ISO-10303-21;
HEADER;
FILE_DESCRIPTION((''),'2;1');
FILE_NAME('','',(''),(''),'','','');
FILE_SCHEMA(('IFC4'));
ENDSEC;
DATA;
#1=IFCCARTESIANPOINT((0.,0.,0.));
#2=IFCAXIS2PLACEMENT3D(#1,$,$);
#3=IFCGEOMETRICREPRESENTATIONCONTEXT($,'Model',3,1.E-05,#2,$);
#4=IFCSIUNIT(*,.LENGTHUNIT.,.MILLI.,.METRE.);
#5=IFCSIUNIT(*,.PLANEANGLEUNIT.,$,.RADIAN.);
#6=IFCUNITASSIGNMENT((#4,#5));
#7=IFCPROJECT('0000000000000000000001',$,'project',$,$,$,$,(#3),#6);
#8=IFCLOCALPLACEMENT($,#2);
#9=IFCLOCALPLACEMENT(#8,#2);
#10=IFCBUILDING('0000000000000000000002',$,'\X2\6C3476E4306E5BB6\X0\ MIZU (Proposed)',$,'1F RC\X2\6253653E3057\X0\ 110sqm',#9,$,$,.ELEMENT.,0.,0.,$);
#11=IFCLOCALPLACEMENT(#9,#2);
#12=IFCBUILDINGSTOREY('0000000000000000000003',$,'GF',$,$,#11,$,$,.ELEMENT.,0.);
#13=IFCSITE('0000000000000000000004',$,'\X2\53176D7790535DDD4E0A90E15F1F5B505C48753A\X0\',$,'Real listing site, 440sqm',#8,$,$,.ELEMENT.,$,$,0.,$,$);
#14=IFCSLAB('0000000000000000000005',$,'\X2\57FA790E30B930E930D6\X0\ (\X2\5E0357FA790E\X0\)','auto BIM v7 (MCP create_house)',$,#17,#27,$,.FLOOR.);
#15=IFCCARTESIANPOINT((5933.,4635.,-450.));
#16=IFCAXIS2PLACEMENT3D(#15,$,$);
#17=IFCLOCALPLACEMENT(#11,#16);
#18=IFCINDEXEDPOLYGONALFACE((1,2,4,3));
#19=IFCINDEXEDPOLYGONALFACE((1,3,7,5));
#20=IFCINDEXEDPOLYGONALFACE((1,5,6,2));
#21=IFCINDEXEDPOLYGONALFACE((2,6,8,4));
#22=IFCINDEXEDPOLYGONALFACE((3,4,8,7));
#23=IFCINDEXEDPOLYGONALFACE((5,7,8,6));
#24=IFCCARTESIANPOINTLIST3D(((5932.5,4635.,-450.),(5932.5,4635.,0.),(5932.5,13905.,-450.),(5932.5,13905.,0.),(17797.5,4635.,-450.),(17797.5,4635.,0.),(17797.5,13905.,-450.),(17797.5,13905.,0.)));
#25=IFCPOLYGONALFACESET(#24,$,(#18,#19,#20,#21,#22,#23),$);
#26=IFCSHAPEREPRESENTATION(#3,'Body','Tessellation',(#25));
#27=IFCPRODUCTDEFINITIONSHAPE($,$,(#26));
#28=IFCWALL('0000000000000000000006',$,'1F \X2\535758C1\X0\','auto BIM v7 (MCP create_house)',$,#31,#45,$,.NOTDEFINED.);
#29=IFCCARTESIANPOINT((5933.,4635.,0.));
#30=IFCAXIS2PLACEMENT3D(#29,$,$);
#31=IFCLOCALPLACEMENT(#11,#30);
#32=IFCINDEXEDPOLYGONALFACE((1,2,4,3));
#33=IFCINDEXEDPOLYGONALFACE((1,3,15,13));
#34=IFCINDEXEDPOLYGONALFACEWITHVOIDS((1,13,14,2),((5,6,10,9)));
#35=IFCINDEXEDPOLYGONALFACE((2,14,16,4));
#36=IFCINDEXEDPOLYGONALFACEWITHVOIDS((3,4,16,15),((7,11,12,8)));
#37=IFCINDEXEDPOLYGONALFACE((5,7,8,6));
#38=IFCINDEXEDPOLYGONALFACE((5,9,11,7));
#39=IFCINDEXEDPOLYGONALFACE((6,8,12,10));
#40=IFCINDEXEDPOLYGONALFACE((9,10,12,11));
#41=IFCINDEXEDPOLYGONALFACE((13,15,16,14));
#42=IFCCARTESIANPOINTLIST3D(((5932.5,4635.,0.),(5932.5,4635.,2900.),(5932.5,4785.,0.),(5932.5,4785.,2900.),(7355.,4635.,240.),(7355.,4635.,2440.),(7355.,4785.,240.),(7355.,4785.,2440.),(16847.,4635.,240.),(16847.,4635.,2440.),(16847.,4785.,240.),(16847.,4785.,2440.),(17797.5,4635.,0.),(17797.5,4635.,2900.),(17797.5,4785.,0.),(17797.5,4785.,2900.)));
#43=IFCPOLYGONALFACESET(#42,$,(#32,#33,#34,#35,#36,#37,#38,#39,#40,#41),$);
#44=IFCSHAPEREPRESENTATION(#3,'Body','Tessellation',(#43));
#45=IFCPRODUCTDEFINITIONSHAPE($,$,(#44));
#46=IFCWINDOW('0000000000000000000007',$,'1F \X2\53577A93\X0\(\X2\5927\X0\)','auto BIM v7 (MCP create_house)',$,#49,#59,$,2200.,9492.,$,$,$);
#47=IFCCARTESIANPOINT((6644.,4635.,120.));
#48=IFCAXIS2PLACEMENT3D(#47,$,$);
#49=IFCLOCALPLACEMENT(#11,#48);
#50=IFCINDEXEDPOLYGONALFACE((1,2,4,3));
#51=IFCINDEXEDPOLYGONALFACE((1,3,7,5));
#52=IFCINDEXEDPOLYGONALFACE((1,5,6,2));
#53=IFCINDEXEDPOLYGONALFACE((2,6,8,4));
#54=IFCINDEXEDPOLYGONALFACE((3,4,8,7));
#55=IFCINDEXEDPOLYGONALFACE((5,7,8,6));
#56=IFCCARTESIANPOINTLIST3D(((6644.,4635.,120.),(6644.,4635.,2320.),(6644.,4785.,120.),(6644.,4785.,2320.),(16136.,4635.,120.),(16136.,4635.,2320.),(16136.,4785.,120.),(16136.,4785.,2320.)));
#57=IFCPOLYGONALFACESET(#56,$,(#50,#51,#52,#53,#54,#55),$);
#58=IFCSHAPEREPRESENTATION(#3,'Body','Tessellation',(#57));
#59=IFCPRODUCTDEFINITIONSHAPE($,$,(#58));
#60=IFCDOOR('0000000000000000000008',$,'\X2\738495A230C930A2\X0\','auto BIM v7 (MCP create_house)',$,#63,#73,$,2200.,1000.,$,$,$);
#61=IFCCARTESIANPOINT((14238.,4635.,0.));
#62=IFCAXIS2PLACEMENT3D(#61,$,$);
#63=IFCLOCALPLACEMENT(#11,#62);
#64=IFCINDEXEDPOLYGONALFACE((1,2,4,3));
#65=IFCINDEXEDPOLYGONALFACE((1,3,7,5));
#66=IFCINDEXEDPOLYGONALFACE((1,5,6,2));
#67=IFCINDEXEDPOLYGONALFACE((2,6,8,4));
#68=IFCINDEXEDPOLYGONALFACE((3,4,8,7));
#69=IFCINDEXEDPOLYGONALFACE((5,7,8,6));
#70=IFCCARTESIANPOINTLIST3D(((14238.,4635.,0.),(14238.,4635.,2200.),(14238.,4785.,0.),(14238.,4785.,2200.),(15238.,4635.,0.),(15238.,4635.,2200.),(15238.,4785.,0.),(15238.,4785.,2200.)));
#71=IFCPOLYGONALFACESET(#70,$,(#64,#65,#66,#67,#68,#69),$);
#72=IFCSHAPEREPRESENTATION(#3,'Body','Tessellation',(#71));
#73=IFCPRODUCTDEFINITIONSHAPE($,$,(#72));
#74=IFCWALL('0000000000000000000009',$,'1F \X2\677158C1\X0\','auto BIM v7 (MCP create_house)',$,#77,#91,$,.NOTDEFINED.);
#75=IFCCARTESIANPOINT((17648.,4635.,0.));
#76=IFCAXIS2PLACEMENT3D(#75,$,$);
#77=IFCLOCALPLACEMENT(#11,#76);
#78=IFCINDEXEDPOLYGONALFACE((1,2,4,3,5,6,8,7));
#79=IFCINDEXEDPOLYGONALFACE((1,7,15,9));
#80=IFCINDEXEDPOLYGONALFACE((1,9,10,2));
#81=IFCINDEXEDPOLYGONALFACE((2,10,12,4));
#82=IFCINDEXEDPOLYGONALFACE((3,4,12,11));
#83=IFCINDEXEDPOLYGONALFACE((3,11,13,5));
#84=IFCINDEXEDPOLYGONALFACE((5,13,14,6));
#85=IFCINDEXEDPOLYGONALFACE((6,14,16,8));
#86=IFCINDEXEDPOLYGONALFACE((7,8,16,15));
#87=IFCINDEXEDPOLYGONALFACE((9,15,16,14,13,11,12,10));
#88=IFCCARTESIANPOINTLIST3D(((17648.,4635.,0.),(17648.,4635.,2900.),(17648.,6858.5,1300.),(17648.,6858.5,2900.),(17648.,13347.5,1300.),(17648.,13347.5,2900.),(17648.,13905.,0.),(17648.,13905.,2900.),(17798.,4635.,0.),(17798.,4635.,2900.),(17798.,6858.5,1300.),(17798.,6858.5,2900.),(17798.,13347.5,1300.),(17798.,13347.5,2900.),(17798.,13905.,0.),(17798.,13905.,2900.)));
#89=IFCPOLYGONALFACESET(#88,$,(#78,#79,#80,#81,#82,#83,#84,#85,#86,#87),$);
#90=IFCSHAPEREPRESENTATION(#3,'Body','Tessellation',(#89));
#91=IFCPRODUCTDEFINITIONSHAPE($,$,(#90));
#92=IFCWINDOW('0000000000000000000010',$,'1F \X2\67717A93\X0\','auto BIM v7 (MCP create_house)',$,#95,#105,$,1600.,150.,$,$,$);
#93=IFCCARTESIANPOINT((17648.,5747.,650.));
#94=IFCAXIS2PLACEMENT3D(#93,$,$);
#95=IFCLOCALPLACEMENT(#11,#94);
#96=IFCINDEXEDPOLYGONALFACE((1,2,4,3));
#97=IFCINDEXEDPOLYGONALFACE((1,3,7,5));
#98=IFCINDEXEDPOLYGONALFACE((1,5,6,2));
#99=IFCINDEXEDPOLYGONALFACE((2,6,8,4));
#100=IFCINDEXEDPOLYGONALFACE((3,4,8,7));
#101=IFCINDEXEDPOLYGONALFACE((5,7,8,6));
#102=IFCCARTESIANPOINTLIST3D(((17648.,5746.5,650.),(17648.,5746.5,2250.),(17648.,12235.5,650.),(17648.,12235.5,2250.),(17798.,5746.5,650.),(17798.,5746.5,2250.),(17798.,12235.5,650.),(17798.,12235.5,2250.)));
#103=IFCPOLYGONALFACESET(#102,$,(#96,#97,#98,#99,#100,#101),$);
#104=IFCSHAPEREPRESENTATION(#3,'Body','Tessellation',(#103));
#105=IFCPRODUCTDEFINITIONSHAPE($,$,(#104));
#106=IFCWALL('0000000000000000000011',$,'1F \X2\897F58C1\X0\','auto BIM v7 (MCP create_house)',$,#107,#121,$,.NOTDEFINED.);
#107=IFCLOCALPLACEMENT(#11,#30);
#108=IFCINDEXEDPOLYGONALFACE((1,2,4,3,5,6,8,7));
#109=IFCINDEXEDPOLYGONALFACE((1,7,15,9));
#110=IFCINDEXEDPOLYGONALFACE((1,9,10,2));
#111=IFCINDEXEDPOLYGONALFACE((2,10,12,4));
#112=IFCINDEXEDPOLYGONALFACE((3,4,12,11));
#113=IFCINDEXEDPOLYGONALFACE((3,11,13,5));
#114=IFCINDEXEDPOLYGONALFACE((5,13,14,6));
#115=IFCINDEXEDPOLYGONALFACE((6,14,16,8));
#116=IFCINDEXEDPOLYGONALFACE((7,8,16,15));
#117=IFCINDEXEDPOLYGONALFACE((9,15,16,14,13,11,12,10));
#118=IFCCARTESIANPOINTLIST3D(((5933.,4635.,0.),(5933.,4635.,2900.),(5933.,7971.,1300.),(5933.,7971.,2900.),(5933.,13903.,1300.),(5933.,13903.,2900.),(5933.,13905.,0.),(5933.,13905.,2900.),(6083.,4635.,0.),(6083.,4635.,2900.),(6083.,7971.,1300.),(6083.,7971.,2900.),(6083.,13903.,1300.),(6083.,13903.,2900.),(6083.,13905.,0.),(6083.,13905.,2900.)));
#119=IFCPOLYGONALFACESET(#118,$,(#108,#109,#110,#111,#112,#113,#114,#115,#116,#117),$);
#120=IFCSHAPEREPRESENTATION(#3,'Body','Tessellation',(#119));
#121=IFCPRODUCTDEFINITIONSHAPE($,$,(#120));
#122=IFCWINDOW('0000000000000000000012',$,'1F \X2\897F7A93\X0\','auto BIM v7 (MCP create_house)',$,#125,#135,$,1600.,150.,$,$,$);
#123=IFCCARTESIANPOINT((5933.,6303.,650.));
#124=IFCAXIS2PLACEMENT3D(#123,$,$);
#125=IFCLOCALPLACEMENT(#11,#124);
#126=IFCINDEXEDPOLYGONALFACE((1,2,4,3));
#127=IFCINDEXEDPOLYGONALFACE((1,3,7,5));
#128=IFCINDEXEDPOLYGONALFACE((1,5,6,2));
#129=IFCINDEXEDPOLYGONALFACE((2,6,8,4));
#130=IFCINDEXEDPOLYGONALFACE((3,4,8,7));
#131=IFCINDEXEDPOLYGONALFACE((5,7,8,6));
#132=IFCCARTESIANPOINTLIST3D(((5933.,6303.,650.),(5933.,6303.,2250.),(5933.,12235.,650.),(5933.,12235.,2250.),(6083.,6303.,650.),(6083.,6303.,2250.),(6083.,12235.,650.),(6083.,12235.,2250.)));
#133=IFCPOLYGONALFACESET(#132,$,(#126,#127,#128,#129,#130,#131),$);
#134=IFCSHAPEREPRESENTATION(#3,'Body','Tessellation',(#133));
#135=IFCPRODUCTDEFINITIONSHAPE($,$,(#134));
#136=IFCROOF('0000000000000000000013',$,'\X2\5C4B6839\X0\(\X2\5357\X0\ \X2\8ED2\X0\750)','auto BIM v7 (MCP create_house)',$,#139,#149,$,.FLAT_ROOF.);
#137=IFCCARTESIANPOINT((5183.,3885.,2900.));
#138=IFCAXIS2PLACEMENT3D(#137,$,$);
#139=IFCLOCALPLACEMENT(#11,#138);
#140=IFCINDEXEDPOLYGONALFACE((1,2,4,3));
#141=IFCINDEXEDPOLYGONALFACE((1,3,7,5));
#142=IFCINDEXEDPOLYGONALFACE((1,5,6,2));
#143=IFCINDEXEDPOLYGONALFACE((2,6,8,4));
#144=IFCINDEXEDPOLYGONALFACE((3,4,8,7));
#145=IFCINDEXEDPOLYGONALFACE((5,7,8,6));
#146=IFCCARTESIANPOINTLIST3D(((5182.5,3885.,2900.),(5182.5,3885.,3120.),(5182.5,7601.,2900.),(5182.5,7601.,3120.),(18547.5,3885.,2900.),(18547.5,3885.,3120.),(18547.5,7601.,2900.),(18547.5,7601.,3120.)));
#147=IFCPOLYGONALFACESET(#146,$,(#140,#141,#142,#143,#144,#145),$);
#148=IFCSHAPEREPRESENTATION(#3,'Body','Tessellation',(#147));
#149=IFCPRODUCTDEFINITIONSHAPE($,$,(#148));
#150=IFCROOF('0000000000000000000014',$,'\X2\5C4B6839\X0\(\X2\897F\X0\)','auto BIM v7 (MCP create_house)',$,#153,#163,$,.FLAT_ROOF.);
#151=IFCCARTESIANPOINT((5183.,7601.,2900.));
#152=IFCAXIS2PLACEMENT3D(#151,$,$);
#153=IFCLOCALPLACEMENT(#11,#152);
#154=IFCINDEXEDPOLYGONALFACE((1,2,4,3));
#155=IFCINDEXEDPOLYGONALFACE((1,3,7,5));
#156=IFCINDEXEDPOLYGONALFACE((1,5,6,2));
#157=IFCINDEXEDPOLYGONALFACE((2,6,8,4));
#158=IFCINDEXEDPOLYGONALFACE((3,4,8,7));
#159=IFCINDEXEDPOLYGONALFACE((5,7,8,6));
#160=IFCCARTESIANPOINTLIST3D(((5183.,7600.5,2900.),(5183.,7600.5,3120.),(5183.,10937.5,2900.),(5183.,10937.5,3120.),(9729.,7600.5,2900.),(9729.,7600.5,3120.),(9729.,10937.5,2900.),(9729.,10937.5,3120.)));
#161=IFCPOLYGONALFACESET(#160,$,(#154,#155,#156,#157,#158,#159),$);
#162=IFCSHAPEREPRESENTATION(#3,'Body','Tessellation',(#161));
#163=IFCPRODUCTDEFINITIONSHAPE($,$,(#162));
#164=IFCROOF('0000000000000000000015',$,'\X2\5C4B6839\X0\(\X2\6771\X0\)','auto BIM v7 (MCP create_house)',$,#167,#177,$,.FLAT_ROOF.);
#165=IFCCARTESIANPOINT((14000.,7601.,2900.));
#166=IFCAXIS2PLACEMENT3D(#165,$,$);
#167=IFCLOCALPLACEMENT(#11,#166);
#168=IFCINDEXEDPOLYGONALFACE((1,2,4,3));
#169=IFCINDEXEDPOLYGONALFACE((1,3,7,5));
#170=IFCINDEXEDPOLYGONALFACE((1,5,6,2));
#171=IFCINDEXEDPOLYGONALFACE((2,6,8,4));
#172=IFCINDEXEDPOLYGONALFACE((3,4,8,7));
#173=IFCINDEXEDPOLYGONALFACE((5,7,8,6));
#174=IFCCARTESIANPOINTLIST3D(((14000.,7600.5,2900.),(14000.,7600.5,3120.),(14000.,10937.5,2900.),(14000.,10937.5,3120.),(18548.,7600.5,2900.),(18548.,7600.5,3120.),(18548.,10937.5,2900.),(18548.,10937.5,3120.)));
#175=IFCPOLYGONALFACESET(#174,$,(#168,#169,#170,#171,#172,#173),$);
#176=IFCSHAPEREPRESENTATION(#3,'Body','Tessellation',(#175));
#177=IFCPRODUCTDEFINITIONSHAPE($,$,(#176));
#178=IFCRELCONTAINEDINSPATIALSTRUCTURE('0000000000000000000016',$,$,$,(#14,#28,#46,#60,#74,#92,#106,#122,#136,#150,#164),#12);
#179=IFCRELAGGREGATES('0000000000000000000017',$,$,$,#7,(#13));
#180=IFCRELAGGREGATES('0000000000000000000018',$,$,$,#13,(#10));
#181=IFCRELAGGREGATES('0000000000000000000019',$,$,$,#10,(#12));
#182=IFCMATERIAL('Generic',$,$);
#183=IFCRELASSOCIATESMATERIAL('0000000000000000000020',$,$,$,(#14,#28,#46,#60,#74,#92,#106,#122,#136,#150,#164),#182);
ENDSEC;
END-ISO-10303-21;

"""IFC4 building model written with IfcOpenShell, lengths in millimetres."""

from ifc_helpers import new_model, si_unit, frame, frame_2d, origin, place, context, project, spatial, rectangle, extrude, material, element, fill, save


model = new_model("IFC4")

# Units and contexts
model_context = context("Model", 3, precision=1e-05, world=origin())
ifc_project = project(units=[si_unit("LENGTHUNIT", "METRE", prefix="MILLI"), si_unit("PLANEANGLEUNIT", "RADIAN")], contexts=[model_context])

# Site, building, storey
site_placement = place(None, origin())
site = spatial("IfcSite", under=ifc_project, at=site_placement, Name="北海道川上郡弟子屈町", ObjectType="Real listing site, 440sqm", CompositionType="ELEMENT", RefElevation=0.0)
building_placement = place(site_placement, origin())
building = spatial("IfcBuilding", under=site, at=building_placement, Name="水盤の家 MIZU (Proposed)", ObjectType="1F RC打放し 110sqm", CompositionType="ELEMENT", ElevationOfRefHeight=0.0, ElevationOfTerrain=0.0)
storey_placement = place(building_placement, origin())
storey = spatial("IfcBuildingStorey", under=building, at=storey_placement, Name="GF", CompositionType="ELEMENT", Elevation=0.0)

# Slab
ifc_material = material(Name="Generic")
slab_1_placement = place(storey_placement, frame((5933.0, 4635.0, -450.0)))
element("IfcSlab", 1, at=slab_1_placement, inside=storey, material=ifc_material, Name="基礎スラブ (布基礎)", Description="auto BIM v7 (MCP create_house)", PredefinedType="FLOOR", context=model_context, shape_type="SweptSolid", body=[
    extrude(rectangle(XDim=11865.0, YDim=9270.0, at=frame_2d((5932.0, 4635.0))), frame((5933.0, 4635.0, -450.0)), (0.0, 0.0, 1.0), 450.0),
])

# Wall, openings, window, door
wall_1_placement = place(storey_placement, frame((5933.0, 4635.0, 0.0)))
wall_1 = element("IfcWall", 2, at=wall_1_placement, inside=storey, material=ifc_material, Name="1F 南壁", Description="auto BIM v7 (MCP create_house)", PredefinedType="NOTDEFINED", context=model_context, shape_type="SweptSolid", body=[
    extrude(rectangle(XDim=11865.0, YDim=150.0, at=frame_2d((5932.0, 75.0))), frame((5933.0, 4635.0, 0.0)), (0.0, 0.0, 1.0), 2900.0),
])
opening_1_placement = place(storey_placement, frame((6644.0, 4635.0, 120.0)))
opening_1 = element("IfcOpeningElement", 3, at=opening_1_placement, cuts=wall_1, PredefinedType="NOTDEFINED", context=model_context, shape_type="SweptSolid", body=[
    extrude(rectangle(XDim=9492.0, YDim=150.0, at=frame_2d((4746.0, 75.0))), frame((6644.0, 4635.0, 120.0)), (0.0, 0.0, 1.0), 2200.0),
])
opening_2_placement = place(storey_placement, frame((14238.0, 4635.0, 0.0)))
opening_2 = element("IfcOpeningElement", 4, at=opening_2_placement, cuts=wall_1, PredefinedType="NOTDEFINED", context=model_context, shape_type="SweptSolid", body=[
    extrude(rectangle(XDim=1000.0, YDim=150.0, at=frame_2d((500.0, 75.0))), frame((14238.0, 4635.0, 0.0)), (0.0, 0.0, 1.0), 2200.0),
])
window_1_placement = place(storey_placement, frame((6644.0, 4635.0, 120.0)))
window_1 = element("IfcWindow", 5, at=window_1_placement, inside=storey, material=ifc_material, Name="1F 南窓(大)", Description="auto BIM v7 (MCP create_house)", OverallHeight=2200.0, OverallWidth=9492.0, context=model_context, shape_type="SweptSolid", body=[
    extrude(rectangle(XDim=9492.0, YDim=150.0, at=frame_2d((4746.0, 75.0))), frame((6644.0, 4635.0, 120.0)), (0.0, 0.0, 1.0), 2200.0),
])
fill(opening_1, window_1)
door_placement = place(storey_placement, frame((14238.0, 4635.0, 0.0)))
door = element("IfcDoor", 6, at=door_placement, inside=storey, material=ifc_material, Name="玄関ドア", Description="auto BIM v7 (MCP create_house)", OverallHeight=2200.0, OverallWidth=1000.0, context=model_context, shape_type="SweptSolid", body=[
    extrude(rectangle(XDim=1000.0, YDim=150.0, at=frame_2d((500.0, 75.0))), frame((14238.0, 4635.0, 0.0)), (0.0, 0.0, 1.0), 2200.0),
])
fill(opening_2, door)

# Walls, openings, windows
wall_2_placement = place(storey_placement, frame((17648.0, 4635.0, 0.0)))
wall_2 = element("IfcWall", 7, at=wall_2_placement, inside=storey, material=ifc_material, Name="1F 東壁", Description="auto BIM v7 (MCP create_house)", PredefinedType="NOTDEFINED", context=model_context, shape_type="SweptSolid", body=[
    extrude(rectangle(XDim=150.0, YDim=9270.0, at=frame_2d((75.0, 4635.0))), frame((17648.0, 4635.0, 0.0)), (0.0, 0.0, 1.0), 2900.0),
])
opening_3_placement = place(storey_placement, frame((17648.0, 5747.0, 650.0)))
opening_3 = element("IfcOpeningElement", 8, at=opening_3_placement, cuts=wall_2, PredefinedType="NOTDEFINED", context=model_context, shape_type="SweptSolid", body=[
    extrude(rectangle(XDim=150.0, YDim=6489.0, at=frame_2d((75.0, 3244.0))), frame((17648.0, 5747.0, 650.0)), (0.0, 0.0, 1.0), 1600.0),
])
window_2_placement = place(storey_placement, frame((17648.0, 5747.0, 650.0)))
window_2 = element("IfcWindow", 9, at=window_2_placement, inside=storey, material=ifc_material, Name="1F 東窓", Description="auto BIM v7 (MCP create_house)", OverallHeight=1600.0, OverallWidth=150.0, context=model_context, shape_type="SweptSolid", body=[
    extrude(rectangle(XDim=150.0, YDim=6489.0, at=frame_2d((75.0, 3244.0))), frame((17648.0, 5747.0, 650.0)), (0.0, 0.0, 1.0), 1600.0),
])
fill(opening_3, window_2)
wall_3_placement = place(storey_placement, frame((5933.0, 4635.0, 0.0)))
wall_3 = element("IfcWall", 10, at=wall_3_placement, inside=storey, material=ifc_material, Name="1F 西壁", Description="auto BIM v7 (MCP create_house)", PredefinedType="NOTDEFINED", context=model_context, shape_type="SweptSolid", body=[
    extrude(rectangle(XDim=150.0, YDim=9270.0, at=frame_2d((75.0, 4635.0))), frame((5933.0, 4635.0, 0.0)), (0.0, 0.0, 1.0), 2900.0),
])
opening_4_placement = place(storey_placement, frame((5933.0, 6303.0, 650.0)))
opening_4 = element("IfcOpeningElement", 11, at=opening_4_placement, cuts=wall_3, PredefinedType="NOTDEFINED", context=model_context, shape_type="SweptSolid", body=[
    extrude(rectangle(XDim=150.0, YDim=5932.0, at=frame_2d((75.0, 2966.0))), frame((5933.0, 6303.0, 650.0)), (0.0, 0.0, 1.0), 1600.0),
])
window_3_placement = place(storey_placement, frame((5933.0, 6303.0, 650.0)))
window_3 = element("IfcWindow", 12, at=window_3_placement, inside=storey, material=ifc_material, Name="1F 西窓", Description="auto BIM v7 (MCP create_house)", OverallHeight=1600.0, OverallWidth=150.0, context=model_context, shape_type="SweptSolid", body=[
    extrude(rectangle(XDim=150.0, YDim=5932.0, at=frame_2d((75.0, 2966.0))), frame((5933.0, 6303.0, 650.0)), (0.0, 0.0, 1.0), 1600.0),
])
fill(opening_4, window_3)

# Roofs
roof_1_placement = place(storey_placement, frame((5183.0, 3885.0, 2900.0)))
element("IfcRoof", 13, at=roof_1_placement, inside=storey, material=ifc_material, Name="屋根(南 軒750)", Description="auto BIM v7 (MCP create_house)", PredefinedType="FLAT_ROOF", context=model_context, shape_type="SweptSolid", body=[
    extrude(rectangle(XDim=13365.0, YDim=3716.0, at=frame_2d((6682.0, 1858.0))), frame((5183.0, 3885.0, 2900.0)), (0.0, 0.0, 1.0), 220.0),
])
roof_2_placement = place(storey_placement, frame((5183.0, 7601.0, 2900.0)))
element("IfcRoof", 14, at=roof_2_placement, inside=storey, material=ifc_material, Name="屋根(西)", Description="auto BIM v7 (MCP create_house)", PredefinedType="FLAT_ROOF", context=model_context, shape_type="SweptSolid", body=[
    extrude(rectangle(XDim=4546.0, YDim=3337.0, at=frame_2d((2273.0, 1668.0))), frame((5183.0, 7601.0, 2900.0)), (0.0, 0.0, 1.0), 220.0),
])
roof_3_placement = place(storey_placement, frame((14000.0, 7601.0, 2900.0)))
element("IfcRoof", 15, at=roof_3_placement, inside=storey, material=ifc_material, Name="屋根(東)", Description="auto BIM v7 (MCP create_house)", PredefinedType="FLAT_ROOF", context=model_context, shape_type="SweptSolid", body=[
    extrude(rectangle(XDim=4548.0, YDim=3337.0, at=frame_2d((2274.0, 1668.0))), frame((14000.0, 7601.0, 2900.0)), (0.0, 0.0, 1.0), 220.0),
])

save(model, "model.ifc")
